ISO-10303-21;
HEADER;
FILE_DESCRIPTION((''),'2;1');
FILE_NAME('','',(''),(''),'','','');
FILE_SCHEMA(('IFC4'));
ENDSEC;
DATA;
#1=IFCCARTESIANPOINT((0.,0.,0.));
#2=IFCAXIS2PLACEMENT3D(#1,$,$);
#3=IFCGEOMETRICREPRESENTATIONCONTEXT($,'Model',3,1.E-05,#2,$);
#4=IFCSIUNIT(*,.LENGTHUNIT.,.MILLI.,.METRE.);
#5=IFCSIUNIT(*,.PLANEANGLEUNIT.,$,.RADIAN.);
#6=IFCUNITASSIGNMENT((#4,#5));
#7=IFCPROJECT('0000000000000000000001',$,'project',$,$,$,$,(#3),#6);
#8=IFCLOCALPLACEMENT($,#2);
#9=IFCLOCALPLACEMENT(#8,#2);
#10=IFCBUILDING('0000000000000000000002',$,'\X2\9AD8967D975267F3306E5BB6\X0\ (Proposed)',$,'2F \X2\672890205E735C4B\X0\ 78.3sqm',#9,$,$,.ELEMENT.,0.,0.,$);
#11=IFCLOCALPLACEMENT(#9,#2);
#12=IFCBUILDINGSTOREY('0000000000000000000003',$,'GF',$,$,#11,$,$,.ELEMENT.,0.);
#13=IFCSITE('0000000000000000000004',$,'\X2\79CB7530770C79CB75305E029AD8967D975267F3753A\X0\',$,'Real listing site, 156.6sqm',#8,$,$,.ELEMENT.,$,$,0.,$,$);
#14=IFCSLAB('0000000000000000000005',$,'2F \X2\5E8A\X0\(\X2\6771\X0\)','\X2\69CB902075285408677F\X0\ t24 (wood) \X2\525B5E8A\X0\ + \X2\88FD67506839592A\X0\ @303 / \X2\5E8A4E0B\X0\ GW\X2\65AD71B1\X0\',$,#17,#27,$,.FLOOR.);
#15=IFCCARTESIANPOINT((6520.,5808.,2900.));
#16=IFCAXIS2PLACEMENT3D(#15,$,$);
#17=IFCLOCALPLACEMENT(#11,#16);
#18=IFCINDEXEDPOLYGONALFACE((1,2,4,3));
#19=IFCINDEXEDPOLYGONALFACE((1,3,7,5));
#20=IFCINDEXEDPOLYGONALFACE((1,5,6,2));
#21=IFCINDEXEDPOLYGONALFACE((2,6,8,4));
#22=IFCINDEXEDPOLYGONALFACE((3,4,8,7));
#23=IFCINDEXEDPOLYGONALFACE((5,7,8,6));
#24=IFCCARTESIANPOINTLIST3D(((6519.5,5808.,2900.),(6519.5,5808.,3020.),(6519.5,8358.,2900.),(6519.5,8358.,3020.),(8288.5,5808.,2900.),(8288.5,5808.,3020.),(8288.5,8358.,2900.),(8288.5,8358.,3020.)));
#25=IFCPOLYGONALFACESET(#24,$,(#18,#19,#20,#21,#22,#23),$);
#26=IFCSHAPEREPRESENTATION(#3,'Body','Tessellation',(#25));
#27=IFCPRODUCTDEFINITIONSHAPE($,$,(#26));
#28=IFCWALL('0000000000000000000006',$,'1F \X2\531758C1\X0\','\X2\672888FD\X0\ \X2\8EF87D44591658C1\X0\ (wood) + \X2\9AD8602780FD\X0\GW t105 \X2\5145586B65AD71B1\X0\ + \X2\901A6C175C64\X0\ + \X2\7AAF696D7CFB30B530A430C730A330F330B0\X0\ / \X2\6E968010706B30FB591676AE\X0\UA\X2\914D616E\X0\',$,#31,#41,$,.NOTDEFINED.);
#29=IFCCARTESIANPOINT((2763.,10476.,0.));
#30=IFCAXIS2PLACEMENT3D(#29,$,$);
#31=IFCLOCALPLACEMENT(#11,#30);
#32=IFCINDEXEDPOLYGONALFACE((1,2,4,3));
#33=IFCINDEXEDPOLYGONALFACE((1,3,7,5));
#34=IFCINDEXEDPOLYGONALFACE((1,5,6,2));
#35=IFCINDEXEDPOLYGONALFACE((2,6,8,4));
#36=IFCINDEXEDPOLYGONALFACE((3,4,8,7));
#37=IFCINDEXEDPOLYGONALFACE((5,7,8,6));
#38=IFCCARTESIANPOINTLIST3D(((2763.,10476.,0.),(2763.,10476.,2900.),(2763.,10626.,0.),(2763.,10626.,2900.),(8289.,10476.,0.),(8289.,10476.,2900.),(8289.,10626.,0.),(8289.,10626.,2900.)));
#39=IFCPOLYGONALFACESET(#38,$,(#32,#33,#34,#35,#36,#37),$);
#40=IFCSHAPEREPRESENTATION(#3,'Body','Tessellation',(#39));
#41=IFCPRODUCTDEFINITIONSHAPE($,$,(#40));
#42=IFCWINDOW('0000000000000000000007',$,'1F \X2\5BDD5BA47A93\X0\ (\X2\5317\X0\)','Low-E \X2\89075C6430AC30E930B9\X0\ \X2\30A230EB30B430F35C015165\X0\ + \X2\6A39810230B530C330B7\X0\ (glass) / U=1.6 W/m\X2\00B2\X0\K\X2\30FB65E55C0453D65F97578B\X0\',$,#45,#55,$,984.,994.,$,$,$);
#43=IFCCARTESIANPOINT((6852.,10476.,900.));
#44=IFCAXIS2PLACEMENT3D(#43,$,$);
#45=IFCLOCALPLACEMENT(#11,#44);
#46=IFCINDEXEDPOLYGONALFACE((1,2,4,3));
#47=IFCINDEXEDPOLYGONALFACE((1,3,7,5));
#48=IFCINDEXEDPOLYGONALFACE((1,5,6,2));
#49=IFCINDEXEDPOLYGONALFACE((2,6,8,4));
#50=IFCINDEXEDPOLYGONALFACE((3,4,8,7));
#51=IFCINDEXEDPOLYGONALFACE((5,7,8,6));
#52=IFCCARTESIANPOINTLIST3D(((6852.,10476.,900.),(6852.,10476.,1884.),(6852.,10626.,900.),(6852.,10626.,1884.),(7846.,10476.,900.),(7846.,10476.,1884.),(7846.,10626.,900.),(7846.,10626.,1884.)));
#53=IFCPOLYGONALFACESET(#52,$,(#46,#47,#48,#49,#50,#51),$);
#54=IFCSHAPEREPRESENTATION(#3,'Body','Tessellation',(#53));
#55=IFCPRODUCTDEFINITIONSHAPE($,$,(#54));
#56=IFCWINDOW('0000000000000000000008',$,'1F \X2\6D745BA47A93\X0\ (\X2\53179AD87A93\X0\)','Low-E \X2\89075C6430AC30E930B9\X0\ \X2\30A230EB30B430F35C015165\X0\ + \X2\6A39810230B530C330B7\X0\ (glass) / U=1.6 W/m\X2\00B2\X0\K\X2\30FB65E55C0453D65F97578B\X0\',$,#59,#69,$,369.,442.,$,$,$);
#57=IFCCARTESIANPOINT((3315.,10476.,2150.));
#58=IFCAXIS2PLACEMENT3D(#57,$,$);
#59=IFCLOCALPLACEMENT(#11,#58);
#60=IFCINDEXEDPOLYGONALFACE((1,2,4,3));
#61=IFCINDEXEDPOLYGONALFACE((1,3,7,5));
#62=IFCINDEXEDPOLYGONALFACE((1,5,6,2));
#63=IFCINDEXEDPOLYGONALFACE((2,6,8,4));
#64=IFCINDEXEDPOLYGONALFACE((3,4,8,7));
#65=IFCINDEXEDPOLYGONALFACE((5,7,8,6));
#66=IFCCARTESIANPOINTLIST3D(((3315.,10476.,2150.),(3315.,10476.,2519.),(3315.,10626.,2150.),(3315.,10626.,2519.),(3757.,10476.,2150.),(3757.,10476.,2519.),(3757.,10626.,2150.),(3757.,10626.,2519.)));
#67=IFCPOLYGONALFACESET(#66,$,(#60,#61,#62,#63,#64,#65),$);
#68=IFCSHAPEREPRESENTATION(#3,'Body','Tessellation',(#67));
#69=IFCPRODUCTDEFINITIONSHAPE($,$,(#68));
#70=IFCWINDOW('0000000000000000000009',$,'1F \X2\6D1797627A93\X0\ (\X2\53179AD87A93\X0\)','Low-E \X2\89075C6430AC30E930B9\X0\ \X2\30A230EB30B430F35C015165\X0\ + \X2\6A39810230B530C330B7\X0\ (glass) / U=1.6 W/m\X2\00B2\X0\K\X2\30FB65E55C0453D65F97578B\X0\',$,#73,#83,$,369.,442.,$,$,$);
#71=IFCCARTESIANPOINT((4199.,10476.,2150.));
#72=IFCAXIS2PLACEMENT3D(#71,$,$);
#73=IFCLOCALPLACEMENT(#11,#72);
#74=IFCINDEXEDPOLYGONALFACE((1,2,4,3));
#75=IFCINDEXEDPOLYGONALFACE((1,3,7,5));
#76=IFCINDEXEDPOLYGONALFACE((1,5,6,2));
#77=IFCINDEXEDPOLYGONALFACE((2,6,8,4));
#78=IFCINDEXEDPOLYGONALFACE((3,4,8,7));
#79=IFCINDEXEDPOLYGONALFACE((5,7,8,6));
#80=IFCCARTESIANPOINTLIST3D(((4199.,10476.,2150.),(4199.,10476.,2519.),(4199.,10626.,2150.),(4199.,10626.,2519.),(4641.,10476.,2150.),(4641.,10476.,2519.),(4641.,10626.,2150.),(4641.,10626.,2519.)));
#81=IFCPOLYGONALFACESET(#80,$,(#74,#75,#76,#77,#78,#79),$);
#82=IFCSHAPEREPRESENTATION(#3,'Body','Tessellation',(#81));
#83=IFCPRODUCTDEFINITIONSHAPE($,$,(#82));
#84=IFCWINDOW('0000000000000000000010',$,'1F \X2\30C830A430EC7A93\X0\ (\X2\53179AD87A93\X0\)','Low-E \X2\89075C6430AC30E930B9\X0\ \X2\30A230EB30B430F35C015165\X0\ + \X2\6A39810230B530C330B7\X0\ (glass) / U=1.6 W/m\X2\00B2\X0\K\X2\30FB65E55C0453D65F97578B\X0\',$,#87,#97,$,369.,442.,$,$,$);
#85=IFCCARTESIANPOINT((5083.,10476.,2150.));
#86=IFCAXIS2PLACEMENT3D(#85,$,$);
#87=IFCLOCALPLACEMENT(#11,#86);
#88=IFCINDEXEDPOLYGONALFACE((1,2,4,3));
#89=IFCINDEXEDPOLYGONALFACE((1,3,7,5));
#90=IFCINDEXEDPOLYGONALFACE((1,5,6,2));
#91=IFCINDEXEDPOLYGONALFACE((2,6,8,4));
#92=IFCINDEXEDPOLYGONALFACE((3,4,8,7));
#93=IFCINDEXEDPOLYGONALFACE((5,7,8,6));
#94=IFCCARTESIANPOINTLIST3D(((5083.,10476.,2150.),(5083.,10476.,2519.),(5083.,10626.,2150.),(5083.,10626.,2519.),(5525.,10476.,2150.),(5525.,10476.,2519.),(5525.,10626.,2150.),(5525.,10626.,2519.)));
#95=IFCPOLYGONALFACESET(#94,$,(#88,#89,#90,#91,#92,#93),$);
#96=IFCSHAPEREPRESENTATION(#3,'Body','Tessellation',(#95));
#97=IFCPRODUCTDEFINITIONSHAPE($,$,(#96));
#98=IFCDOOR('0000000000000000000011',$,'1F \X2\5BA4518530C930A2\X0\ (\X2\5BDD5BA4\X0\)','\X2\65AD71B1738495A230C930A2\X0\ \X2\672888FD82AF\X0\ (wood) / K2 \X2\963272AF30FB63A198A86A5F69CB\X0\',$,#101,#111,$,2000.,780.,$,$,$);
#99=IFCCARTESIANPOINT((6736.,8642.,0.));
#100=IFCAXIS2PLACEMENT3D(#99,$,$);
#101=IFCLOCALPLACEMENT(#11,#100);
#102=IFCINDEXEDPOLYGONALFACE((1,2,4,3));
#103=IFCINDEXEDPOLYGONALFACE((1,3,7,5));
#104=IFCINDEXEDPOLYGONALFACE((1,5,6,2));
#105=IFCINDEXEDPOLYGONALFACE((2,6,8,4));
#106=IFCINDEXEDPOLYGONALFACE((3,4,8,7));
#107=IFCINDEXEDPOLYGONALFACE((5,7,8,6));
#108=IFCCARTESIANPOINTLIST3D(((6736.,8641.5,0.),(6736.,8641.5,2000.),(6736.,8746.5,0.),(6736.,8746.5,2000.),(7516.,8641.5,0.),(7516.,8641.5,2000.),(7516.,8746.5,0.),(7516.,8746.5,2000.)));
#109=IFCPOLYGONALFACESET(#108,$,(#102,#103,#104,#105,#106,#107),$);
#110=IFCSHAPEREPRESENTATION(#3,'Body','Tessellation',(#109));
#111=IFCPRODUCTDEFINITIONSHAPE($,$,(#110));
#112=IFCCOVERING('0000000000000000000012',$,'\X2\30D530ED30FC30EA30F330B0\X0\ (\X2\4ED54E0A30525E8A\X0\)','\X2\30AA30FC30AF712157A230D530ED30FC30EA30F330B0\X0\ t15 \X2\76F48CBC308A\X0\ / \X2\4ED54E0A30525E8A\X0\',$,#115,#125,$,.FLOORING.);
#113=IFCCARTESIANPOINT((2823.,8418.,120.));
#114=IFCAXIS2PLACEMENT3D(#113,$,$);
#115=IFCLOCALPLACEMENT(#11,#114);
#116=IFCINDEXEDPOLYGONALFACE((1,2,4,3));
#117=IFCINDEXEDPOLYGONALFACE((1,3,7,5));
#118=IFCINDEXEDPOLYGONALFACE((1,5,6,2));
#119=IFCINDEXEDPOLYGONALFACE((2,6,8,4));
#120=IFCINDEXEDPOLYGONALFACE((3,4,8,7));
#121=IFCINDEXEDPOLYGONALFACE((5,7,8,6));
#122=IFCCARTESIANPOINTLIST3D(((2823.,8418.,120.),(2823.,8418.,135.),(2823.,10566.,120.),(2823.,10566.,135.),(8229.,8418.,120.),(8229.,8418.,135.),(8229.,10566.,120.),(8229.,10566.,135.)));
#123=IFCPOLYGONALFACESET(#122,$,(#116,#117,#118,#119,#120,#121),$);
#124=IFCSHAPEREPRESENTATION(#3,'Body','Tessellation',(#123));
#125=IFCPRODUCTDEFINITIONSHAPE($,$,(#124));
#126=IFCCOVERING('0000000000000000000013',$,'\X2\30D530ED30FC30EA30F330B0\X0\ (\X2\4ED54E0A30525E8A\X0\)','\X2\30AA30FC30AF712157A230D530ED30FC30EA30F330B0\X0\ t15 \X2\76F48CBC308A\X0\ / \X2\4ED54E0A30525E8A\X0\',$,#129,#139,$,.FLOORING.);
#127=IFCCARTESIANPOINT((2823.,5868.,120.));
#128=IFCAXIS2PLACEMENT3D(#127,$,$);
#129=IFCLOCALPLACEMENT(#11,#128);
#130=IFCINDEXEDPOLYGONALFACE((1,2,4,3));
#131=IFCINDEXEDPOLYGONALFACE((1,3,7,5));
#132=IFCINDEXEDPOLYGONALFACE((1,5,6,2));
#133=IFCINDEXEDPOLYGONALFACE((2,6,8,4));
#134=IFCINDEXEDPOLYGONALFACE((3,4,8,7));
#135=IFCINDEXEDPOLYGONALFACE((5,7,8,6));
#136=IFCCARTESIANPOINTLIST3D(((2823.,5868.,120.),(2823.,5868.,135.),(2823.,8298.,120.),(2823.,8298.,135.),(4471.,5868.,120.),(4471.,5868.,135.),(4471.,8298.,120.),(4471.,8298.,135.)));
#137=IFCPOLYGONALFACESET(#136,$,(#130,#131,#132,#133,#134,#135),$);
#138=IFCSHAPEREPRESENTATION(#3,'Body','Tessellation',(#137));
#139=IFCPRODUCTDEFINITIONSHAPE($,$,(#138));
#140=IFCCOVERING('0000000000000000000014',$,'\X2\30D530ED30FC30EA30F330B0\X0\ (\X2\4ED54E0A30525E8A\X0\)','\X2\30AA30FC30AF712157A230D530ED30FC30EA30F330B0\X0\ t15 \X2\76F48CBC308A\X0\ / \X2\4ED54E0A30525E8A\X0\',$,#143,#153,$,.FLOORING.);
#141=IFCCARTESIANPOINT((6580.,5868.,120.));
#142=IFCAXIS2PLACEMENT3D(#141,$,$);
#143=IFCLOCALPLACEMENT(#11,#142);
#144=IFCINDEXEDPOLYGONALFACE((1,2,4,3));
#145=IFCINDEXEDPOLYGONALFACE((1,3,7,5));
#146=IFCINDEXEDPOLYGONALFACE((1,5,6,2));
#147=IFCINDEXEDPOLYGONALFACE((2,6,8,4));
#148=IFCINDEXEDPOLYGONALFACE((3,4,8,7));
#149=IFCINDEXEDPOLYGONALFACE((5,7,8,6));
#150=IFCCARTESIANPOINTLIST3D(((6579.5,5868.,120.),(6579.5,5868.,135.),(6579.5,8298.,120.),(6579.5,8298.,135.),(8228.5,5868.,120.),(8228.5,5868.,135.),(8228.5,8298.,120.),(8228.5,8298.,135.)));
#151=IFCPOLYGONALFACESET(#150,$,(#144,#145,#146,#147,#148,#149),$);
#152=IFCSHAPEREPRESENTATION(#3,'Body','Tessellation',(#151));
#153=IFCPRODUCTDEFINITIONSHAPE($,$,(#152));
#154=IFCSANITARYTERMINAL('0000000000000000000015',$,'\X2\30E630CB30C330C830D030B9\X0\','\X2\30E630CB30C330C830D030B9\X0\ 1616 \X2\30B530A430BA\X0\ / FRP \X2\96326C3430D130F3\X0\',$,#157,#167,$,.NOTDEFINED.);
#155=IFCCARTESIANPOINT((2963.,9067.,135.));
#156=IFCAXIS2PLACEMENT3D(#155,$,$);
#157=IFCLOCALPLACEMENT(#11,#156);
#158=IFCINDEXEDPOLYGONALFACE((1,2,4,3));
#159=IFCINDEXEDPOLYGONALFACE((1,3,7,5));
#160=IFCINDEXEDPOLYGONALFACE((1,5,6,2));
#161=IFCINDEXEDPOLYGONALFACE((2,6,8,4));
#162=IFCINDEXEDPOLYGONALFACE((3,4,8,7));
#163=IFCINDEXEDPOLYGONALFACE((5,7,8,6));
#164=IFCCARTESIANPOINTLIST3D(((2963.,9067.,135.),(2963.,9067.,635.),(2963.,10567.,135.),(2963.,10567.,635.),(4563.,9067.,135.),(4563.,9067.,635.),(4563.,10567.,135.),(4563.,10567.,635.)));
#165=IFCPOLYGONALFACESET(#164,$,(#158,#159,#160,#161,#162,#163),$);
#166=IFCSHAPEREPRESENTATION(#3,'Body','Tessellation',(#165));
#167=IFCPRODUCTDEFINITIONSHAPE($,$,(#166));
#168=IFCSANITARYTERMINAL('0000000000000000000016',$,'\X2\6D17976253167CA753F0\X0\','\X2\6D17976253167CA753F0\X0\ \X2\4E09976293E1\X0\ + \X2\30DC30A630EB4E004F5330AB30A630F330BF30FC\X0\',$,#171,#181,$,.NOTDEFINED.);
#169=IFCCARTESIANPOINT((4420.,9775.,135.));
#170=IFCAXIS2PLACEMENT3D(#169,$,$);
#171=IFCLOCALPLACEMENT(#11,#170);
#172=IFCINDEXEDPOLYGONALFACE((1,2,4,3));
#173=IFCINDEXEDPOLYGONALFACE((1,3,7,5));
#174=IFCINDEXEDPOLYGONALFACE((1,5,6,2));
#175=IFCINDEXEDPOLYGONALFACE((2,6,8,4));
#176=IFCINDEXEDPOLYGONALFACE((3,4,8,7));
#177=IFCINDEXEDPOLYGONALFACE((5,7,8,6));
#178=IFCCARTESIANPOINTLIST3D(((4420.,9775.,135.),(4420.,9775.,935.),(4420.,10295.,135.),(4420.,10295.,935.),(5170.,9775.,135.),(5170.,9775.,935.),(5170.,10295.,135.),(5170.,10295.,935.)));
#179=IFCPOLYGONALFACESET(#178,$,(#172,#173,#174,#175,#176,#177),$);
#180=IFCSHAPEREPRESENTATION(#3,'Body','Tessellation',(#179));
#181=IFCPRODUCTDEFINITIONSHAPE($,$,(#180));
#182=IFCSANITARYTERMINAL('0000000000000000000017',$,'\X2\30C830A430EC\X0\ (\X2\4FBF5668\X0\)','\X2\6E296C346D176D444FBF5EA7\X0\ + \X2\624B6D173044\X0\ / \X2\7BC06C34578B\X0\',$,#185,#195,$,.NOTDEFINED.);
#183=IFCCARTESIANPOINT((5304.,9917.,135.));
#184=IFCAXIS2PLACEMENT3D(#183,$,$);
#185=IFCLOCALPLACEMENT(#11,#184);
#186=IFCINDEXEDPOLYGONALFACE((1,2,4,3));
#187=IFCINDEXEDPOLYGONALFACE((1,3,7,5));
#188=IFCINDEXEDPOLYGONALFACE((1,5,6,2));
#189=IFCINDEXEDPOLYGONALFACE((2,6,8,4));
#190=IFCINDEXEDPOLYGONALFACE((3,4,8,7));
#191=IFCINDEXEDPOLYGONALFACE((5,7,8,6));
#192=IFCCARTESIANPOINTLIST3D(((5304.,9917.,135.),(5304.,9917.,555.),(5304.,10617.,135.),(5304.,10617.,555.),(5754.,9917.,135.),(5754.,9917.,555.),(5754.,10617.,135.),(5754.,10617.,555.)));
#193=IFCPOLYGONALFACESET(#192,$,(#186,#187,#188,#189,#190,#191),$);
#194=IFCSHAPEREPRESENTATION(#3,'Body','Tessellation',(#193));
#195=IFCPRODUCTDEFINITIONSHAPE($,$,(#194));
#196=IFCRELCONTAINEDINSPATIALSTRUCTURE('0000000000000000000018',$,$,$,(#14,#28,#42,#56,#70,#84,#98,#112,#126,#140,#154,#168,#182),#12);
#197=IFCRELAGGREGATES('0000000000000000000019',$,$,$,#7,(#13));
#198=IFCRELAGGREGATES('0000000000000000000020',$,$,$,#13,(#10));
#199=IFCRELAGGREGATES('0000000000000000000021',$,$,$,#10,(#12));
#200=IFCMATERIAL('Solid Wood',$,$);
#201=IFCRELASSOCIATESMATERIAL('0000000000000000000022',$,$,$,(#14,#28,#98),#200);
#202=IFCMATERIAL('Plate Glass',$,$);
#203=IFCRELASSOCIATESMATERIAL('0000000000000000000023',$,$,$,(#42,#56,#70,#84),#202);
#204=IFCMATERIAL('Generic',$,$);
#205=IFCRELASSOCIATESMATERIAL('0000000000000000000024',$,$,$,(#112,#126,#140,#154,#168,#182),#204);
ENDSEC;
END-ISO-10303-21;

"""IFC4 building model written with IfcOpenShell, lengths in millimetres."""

from ifc_helpers import new_model, si_unit, frame, frame_2d, origin, place, context, project, spatial, rectangle, extrude, material, element, fill, save


model = new_model("IFC4")

# Units and contexts
model_context = context("Model", 3, precision=1e-05, world=origin())
ifc_project = project(units=[si_unit("LENGTHUNIT", "METRE", prefix="MILLI"), si_unit("PLANEANGLEUNIT", "RADIAN")], contexts=[model_context])

# Site, building, storey
site_placement = place(None, origin())
site = spatial("IfcSite", under=ifc_project, at=site_placement, Name="秋田県秋田市高陽青柳町", ObjectType="Real listing site, 156.6sqm", CompositionType="ELEMENT", RefElevation=0.0)
building_placement = place(site_placement, origin())
building = spatial("IfcBuilding", under=site, at=building_placement, Name="高陽青柳の家 (Proposed)", ObjectType="2F 木造平屋 78.3sqm", CompositionType="ELEMENT", ElevationOfRefHeight=0.0, ElevationOfTerrain=0.0)
storey_placement = place(building_placement, origin())
storey = spatial("IfcBuildingStorey", under=building, at=storey_placement, Name="GF", CompositionType="ELEMENT", Elevation=0.0)

# Slab
ifc_material_1 = material(Name="Solid Wood")
slab_1_placement = place(storey_placement, frame((6520.0, 5808.0, 2900.0)))
element("IfcSlab", 1, at=slab_1_placement, inside=storey, material=ifc_material_1, Name="2F 床(東)", Description="構造用合板 t24 (wood) 剛床 + 製材根太 @303 / 床下 GW断熱", PredefinedType="FLOOR", context=model_context, shape_type="SweptSolid", body=[
    extrude(rectangle(XDim=1769.0, YDim=2550.0, at=frame_2d((884.0, 1275.0))), frame((6520.0, 5808.0, 2900.0)), (0.0, 0.0, 1.0), 120.0),
])

# Wall, openings, windows
wall_1_placement = place(storey_placement, frame((2763.0, 10476.0, 0.0)))
wall_1 = element("IfcWall", 2, at=wall_1_placement, inside=storey, material=ifc_material_1, Name="1F 北壁", Description="木製 軸組外壁 (wood) + 高性能GW t105 充填断熱 + 通気層 + 窯業系サイディング / 準耐火・外皮UA配慮", PredefinedType="NOTDEFINED", context=model_context, shape_type="SweptSolid", body=[
    extrude(rectangle(XDim=5526.0, YDim=150.0, at=frame_2d((2763.0, 75.0))), frame((2763.0, 10476.0, 0.0)), (0.0, 0.0, 1.0), 2900.0),
])
opening_1_placement = place(storey_placement, frame((6852.0, 10476.0, 900.0)))
opening_1 = element("IfcOpeningElement", 3, at=opening_1_placement, cuts=wall_1, PredefinedType="NOTDEFINED", context=model_context, shape_type="SweptSolid", body=[
    extrude(rectangle(XDim=994.0, YDim=150.0, at=frame_2d((497.0, 75.0))), frame((6852.0, 10476.0, 900.0)), (0.0, 0.0, 1.0), 984.0),
])
opening_2_placement = place(storey_placement, frame((3315.0, 10476.0, 2150.0)))
opening_2 = element("IfcOpeningElement", 4, at=opening_2_placement, cuts=wall_1, PredefinedType="NOTDEFINED", context=model_context, shape_type="SweptSolid", body=[
    extrude(rectangle(XDim=442.0, YDim=150.0, at=frame_2d((221.0, 75.0))), frame((3315.0, 10476.0, 2150.0)), (0.0, 0.0, 1.0), 369.0),
])
opening_3_placement = place(storey_placement, frame((4199.0, 10476.0, 2150.0)))
opening_3 = element("IfcOpeningElement", 5, at=opening_3_placement, cuts=wall_1, PredefinedType="NOTDEFINED", context=model_context, shape_type="SweptSolid", body=[
    extrude(rectangle(XDim=442.0, YDim=150.0, at=frame_2d((221.0, 75.0))), frame((4199.0, 10476.0, 2150.0)), (0.0, 0.0, 1.0), 369.0),
])
opening_4_placement = place(storey_placement, frame((5083.0, 10476.0, 2150.0)))
opening_4 = element("IfcOpeningElement", 6, at=opening_4_placement, cuts=wall_1, PredefinedType="NOTDEFINED", context=model_context, shape_type="SweptSolid", body=[
    extrude(rectangle(XDim=442.0, YDim=150.0, at=frame_2d((221.0, 75.0))), frame((5083.0, 10476.0, 2150.0)), (0.0, 0.0, 1.0), 369.0),
])
ifc_material_2 = material(Name="Plate Glass")
window_1_placement = place(storey_placement, frame((6852.0, 10476.0, 900.0)))
window_1 = element("IfcWindow", 7, at=window_1_placement, inside=storey, material=ifc_material_2, Name="1F 寝室窓 (北)", Description="Low-E 複層ガラス アルゴン封入 + 樹脂サッシ (glass) / U=1.6 W/m²K・日射取得型", OverallHeight=984.0, OverallWidth=994.0, context=model_context, shape_type="SweptSolid", body=[
    extrude(rectangle(XDim=994.0, YDim=150.0, at=frame_2d((497.0, 75.0))), frame((6852.0, 10476.0, 900.0)), (0.0, 0.0, 1.0), 984.0),
])
fill(opening_1, window_1)
window_2_placement = place(storey_placement, frame((3315.0, 10476.0, 2150.0)))
window_2 = element("IfcWindow", 8, at=window_2_placement, inside=storey, material=ifc_material_2, Name="1F 浴室窓 (北高窓)", Description="Low-E 複層ガラス アルゴン封入 + 樹脂サッシ (glass) / U=1.6 W/m²K・日射取得型", OverallHeight=369.0, OverallWidth=442.0, context=model_context, shape_type="SweptSolid", body=[
    extrude(rectangle(XDim=442.0, YDim=150.0, at=frame_2d((221.0, 75.0))), frame((3315.0, 10476.0, 2150.0)), (0.0, 0.0, 1.0), 369.0),
])
fill(opening_2, window_2)
window_3_placement = place(storey_placement, frame((4199.0, 10476.0, 2150.0)))
window_3 = element("IfcWindow", 9, at=window_3_placement, inside=storey, material=ifc_material_2, Name="1F 洗面窓 (北高窓)", Description="Low-E 複層ガラス アルゴン封入 + 樹脂サッシ (glass) / U=1.6 W/m²K・日射取得型", OverallHeight=369.0, OverallWidth=442.0, context=model_context, shape_type="SweptSolid", body=[
    extrude(rectangle(XDim=442.0, YDim=150.0, at=frame_2d((221.0, 75.0))), frame((4199.0, 10476.0, 2150.0)), (0.0, 0.0, 1.0), 369.0),
])
fill(opening_3, window_3)
window_4_placement = place(storey_placement, frame((5083.0, 10476.0, 2150.0)))
window_4 = element("IfcWindow", 10, at=window_4_placement, inside=storey, material=ifc_material_2, Name="1F トイレ窓 (北高窓)", Description="Low-E 複層ガラス アルゴン封入 + 樹脂サッシ (glass) / U=1.6 W/m²K・日射取得型", OverallHeight=369.0, OverallWidth=442.0, context=model_context, shape_type="SweptSolid", body=[
    extrude(rectangle(XDim=442.0, YDim=150.0, at=frame_2d((221.0, 75.0))), frame((5083.0, 10476.0, 2150.0)), (0.0, 0.0, 1.0), 369.0),
])
fill(opening_4, window_4)

# Door
door_1_placement = place(storey_placement, frame((6736.0, 8642.0, 0.0)))
element("IfcDoor", 11, at=door_1_placement, inside=storey, material=ifc_material_1, Name="1F 室内ドア (寝室)", Description="断熱玄関ドア 木製芯 (wood) / K2 防犯・採風機構", OverallHeight=2000.0, OverallWidth=780.0, context=model_context, shape_type="SweptSolid", body=[
    extrude(rectangle(XDim=780.0, YDim=105.0, at=frame_2d((390.0, 52.0))), frame((6736.0, 8642.0, 0.0)), (0.0, 0.0, 1.0), 2000.0),
])

# Coverings
ifc_material_3 = material(Name="Generic")
covering_1_placement = place(storey_placement, frame((2823.0, 8418.0, 120.0)))
element("IfcCovering", 12, at=covering_1_placement, inside=storey, material=ifc_material_3, Name="フローリング (仕上げ床)", Description="オーク無垢フローリング t15 直貼り / 仕上げ床", PredefinedType="FLOORING", context=model_context, shape_type="SweptSolid", body=[
    extrude(rectangle(XDim=5406.0, YDim=2148.0, at=frame_2d((2703.0, 1074.0))), frame((2823.0, 8418.0, 120.0)), (0.0, 0.0, 1.0), 15.0),
])
covering_2_placement = place(storey_placement, frame((2823.0, 5868.0, 120.0)))
element("IfcCovering", 13, at=covering_2_placement, inside=storey, material=ifc_material_3, Name="フローリング (仕上げ床)", Description="オーク無垢フローリング t15 直貼り / 仕上げ床", PredefinedType="FLOORING", context=model_context, shape_type="SweptSolid", body=[
    extrude(rectangle(XDim=1648.0, YDim=2430.0, at=frame_2d((824.0, 1215.0))), frame((2823.0, 5868.0, 120.0)), (0.0, 0.0, 1.0), 15.0),
])
covering_3_placement = place(storey_placement, frame((6580.0, 5868.0, 120.0)))
element("IfcCovering", 14, at=covering_3_placement, inside=storey, material=ifc_material_3, Name="フローリング (仕上げ床)", Description="オーク無垢フローリング t15 直貼り / 仕上げ床", PredefinedType="FLOORING", context=model_context, shape_type="SweptSolid", body=[
    extrude(rectangle(XDim=1649.0, YDim=2430.0, at=frame_2d((824.0, 1215.0))), frame((6580.0, 5868.0, 120.0)), (0.0, 0.0, 1.0), 15.0),
])

# Sanitary terminals
sanitary_terminal_1_placement = place(storey_placement, frame((2963.0, 9067.0, 135.0)))
element("IfcSanitaryTerminal", 15, at=sanitary_terminal_1_placement, inside=storey, material=ifc_material_3, Name="ユニットバス", Description="ユニットバス 1616 サイズ / FRP 防水パン", PredefinedType="NOTDEFINED", context=model_context, shape_type="SweptSolid", body=[
    extrude(rectangle(XDim=1600.0, YDim=1500.0, at=frame_2d((800.0, 750.0))), frame((2963.0, 9067.0, 135.0)), (0.0, 0.0, 1.0), 500.0),
])
sanitary_terminal_2_placement = place(storey_placement, frame((4420.0, 9775.0, 135.0)))
element("IfcSanitaryTerminal", 16, at=sanitary_terminal_2_placement, inside=storey, material=ifc_material_3, Name="洗面化粧台", Description="洗面化粧台 三面鏡 + ボウル一体カウンター", PredefinedType="NOTDEFINED", context=model_context, shape_type="SweptSolid", body=[
    extrude(rectangle(XDim=750.0, YDim=520.0, at=frame_2d((375.0, 260.0))), frame((4420.0, 9775.0, 135.0)), (0.0, 0.0, 1.0), 800.0),
])
sanitary_terminal_3_placement = place(storey_placement, frame((5304.0, 9917.0, 135.0)))
element("IfcSanitaryTerminal", 17, at=sanitary_terminal_3_placement, inside=storey, material=ifc_material_3, Name="トイレ (便器)", Description="温水洗浄便座 + 手洗い / 節水型", PredefinedType="NOTDEFINED", context=model_context, shape_type="SweptSolid", body=[
    extrude(rectangle(XDim=450.0, YDim=700.0, at=frame_2d((225.0, 350.0))), frame((5304.0, 9917.0, 135.0)), (0.0, 0.0, 1.0), 420.0),
])

save(model, "model.ifc")
